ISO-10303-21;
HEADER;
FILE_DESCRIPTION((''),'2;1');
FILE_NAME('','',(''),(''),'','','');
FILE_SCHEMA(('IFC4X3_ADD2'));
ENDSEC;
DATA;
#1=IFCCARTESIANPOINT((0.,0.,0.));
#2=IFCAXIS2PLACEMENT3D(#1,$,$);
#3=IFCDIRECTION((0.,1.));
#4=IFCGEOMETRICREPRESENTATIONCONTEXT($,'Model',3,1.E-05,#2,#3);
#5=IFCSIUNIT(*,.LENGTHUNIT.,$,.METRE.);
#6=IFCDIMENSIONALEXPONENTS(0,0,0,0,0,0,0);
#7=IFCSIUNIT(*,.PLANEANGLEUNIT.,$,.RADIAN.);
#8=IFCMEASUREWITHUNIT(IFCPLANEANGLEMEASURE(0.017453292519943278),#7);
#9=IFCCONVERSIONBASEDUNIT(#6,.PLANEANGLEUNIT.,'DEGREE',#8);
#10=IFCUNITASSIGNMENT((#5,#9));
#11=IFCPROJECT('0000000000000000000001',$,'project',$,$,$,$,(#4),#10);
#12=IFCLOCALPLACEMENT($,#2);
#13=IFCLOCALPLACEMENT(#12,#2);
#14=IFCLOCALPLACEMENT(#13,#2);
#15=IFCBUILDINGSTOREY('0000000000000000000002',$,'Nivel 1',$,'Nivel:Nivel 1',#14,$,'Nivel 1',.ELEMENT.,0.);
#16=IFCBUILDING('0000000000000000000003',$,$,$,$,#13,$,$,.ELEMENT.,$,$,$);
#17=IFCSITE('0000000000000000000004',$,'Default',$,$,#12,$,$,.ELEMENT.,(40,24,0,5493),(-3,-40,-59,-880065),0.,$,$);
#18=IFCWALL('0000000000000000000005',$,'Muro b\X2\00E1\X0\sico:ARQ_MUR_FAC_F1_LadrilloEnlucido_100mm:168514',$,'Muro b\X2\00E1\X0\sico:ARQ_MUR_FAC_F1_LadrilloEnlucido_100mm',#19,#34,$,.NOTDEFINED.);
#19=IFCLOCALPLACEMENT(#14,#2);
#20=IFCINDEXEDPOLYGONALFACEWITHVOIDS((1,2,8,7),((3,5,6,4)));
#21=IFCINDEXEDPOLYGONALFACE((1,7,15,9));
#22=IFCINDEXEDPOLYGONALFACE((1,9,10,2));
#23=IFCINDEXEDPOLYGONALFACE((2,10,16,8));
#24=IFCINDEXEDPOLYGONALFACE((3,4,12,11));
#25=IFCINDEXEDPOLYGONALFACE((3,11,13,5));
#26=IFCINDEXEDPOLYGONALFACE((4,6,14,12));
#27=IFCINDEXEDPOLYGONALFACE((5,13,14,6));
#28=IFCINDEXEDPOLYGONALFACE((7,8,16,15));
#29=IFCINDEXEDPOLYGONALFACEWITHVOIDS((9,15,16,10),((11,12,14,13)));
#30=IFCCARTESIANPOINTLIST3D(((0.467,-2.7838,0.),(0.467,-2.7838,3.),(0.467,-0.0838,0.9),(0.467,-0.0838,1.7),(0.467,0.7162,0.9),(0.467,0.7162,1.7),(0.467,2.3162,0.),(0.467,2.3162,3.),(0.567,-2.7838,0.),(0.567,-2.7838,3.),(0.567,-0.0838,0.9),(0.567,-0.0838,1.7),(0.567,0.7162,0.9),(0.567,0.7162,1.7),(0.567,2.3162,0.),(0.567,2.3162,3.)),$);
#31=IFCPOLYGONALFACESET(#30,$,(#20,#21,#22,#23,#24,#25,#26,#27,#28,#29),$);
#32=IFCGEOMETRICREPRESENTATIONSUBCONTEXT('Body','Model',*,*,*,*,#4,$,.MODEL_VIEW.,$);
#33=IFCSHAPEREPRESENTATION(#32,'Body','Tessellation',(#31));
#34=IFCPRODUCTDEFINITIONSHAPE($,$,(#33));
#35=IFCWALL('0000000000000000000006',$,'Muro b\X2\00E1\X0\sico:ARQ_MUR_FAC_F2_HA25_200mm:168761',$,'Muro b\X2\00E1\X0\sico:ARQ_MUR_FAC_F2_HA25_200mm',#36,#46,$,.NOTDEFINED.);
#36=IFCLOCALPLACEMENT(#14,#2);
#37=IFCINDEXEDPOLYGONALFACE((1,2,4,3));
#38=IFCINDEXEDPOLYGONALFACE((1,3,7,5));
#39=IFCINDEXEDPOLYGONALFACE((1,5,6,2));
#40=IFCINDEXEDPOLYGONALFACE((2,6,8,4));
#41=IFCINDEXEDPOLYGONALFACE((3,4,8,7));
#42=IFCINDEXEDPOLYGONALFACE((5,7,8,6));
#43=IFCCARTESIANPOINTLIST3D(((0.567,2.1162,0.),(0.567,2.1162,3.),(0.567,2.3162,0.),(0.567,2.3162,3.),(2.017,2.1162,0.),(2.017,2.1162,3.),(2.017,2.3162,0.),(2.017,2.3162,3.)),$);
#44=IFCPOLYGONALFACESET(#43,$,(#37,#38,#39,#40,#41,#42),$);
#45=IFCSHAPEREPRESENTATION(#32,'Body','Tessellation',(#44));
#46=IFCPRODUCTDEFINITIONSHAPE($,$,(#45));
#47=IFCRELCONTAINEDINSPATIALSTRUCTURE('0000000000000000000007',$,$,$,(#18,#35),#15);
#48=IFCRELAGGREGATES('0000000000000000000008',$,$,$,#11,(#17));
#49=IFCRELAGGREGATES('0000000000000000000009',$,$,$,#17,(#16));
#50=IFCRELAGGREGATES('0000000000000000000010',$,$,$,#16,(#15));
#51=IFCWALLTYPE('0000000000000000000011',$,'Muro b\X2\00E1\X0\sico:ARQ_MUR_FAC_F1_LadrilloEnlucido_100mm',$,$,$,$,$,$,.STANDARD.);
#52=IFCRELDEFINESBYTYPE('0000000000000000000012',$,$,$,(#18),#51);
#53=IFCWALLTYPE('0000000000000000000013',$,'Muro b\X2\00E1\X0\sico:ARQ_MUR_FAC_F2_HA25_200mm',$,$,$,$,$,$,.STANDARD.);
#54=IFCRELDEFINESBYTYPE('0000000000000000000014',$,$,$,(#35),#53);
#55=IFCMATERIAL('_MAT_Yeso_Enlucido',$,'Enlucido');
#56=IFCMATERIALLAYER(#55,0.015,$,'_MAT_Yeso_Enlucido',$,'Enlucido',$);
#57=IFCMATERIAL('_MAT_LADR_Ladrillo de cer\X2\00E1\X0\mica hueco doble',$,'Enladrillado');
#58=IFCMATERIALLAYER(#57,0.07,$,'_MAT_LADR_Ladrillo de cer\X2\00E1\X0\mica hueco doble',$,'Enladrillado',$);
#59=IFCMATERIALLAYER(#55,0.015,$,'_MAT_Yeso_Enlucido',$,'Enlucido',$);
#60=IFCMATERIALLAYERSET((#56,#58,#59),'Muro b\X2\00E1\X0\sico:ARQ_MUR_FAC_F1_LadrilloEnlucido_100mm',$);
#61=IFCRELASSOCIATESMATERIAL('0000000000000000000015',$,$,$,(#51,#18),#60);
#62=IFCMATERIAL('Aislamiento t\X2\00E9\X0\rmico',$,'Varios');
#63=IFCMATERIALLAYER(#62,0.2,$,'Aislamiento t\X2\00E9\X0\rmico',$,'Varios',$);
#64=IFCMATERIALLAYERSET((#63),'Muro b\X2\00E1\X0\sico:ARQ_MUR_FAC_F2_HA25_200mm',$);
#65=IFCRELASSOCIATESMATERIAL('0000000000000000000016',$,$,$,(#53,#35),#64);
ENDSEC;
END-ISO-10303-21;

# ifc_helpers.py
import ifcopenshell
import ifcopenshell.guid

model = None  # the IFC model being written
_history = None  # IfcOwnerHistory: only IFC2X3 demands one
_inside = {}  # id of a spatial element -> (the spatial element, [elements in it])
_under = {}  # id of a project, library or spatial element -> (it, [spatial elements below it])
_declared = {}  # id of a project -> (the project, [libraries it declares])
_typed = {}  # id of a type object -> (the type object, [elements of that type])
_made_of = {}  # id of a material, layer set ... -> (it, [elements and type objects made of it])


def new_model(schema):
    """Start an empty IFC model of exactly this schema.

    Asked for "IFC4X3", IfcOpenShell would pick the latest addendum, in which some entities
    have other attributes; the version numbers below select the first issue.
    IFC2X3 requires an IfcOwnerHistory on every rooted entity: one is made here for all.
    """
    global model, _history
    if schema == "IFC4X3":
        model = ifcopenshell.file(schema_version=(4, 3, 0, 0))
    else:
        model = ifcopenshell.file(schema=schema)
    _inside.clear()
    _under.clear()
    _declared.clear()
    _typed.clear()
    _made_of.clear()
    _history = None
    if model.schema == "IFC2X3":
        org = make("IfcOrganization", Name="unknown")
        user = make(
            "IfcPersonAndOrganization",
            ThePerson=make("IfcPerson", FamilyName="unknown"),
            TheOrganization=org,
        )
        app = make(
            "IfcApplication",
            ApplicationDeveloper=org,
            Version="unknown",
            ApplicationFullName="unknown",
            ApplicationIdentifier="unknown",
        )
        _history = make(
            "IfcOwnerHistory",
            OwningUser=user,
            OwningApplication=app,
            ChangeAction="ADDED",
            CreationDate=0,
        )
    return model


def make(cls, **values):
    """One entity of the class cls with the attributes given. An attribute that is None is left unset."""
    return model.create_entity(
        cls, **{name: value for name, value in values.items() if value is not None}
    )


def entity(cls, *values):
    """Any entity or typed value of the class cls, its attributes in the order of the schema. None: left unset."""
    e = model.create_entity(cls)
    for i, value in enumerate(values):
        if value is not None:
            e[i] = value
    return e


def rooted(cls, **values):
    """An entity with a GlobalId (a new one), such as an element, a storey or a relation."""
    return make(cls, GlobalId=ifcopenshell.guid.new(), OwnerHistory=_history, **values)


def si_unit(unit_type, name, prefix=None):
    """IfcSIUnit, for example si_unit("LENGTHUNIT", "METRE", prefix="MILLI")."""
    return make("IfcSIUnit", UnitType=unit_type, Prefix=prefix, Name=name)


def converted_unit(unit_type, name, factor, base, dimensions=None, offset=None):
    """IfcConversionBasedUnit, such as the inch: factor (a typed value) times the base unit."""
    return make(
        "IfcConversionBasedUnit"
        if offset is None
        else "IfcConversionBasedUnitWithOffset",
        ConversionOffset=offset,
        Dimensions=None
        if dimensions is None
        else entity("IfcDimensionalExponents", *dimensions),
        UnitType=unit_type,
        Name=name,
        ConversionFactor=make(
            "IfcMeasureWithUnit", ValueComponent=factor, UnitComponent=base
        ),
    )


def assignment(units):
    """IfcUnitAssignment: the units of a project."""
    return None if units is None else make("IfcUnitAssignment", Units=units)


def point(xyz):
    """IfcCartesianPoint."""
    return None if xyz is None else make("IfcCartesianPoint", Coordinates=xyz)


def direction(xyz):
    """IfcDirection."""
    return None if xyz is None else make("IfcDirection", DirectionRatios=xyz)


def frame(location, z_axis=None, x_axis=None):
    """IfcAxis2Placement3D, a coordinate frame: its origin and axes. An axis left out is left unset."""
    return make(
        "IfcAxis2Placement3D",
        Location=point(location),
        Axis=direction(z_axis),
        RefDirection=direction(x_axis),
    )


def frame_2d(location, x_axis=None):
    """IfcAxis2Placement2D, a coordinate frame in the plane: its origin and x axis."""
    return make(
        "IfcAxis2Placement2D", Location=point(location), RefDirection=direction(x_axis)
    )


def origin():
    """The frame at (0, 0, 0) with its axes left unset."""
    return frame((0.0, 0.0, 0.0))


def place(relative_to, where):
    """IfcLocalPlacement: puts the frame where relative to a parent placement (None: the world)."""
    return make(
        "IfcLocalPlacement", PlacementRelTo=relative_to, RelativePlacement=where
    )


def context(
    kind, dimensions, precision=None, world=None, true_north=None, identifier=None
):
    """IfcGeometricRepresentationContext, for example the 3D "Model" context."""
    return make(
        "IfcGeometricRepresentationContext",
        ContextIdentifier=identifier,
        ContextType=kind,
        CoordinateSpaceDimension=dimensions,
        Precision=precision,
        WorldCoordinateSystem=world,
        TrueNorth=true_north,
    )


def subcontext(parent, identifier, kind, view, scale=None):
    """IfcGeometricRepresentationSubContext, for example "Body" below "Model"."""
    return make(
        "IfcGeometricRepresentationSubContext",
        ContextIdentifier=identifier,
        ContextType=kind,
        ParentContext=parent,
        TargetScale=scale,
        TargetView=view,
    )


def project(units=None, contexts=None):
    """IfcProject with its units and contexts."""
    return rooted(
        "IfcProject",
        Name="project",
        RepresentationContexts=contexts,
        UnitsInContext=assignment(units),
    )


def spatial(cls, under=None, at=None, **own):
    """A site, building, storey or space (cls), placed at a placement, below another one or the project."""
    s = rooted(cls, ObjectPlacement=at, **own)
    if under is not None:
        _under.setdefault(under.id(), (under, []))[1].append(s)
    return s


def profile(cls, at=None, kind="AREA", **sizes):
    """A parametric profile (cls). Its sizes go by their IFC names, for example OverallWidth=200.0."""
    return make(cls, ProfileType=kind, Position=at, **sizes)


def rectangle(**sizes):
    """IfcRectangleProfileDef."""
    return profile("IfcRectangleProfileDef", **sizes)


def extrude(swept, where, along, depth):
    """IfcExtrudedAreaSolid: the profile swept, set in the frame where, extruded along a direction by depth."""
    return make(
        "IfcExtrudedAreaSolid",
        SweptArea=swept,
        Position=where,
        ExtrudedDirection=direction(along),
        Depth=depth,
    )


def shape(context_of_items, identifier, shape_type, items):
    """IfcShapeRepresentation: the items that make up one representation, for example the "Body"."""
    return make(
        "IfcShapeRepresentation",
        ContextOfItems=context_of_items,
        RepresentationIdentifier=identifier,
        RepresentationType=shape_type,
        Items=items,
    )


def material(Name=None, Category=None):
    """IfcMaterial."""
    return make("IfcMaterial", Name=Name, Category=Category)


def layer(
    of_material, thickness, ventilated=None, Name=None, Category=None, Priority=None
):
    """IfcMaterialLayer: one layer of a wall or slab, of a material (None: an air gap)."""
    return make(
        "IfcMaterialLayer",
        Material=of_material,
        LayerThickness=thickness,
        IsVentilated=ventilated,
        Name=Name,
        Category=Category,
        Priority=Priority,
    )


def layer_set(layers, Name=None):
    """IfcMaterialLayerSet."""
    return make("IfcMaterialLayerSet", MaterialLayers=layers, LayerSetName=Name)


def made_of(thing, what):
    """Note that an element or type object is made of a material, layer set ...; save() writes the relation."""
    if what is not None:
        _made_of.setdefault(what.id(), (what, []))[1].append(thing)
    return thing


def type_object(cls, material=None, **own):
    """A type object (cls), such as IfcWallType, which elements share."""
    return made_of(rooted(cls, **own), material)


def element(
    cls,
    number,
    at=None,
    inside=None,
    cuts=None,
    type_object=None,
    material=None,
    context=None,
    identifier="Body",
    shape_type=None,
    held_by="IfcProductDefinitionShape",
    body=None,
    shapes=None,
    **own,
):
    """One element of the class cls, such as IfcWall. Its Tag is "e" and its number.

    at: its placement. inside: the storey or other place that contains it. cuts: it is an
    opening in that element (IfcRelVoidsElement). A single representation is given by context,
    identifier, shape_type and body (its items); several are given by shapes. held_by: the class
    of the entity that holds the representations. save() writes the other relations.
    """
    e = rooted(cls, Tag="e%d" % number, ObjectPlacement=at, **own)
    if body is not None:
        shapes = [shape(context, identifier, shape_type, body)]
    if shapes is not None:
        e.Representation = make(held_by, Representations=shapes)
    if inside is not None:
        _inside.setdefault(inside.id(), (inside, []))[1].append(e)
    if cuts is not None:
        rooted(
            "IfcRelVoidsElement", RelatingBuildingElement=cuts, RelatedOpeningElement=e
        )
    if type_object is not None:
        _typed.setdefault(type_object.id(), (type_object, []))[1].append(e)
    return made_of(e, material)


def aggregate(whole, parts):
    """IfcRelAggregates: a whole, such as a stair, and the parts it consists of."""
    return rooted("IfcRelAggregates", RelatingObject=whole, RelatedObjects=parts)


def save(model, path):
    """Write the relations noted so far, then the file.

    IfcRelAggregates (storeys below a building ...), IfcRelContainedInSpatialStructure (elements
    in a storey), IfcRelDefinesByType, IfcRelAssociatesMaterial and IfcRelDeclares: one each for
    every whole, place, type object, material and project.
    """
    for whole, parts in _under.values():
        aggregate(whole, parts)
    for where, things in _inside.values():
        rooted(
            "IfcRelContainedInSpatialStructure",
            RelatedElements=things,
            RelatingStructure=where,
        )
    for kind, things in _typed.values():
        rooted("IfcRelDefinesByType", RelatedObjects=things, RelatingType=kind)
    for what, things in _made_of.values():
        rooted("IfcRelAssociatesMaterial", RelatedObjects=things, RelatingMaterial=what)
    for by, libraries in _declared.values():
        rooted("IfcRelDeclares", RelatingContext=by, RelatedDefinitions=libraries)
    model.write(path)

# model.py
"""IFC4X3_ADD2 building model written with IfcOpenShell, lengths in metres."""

from ifc_helpers import new_model, entity, si_unit, converted_unit, direction, frame, frame_2d, origin, place, context, subcontext, project, spatial, rectangle, extrude, material, layer, layer_set, type_object, element, save


model = new_model("IFC4X3_ADD2")

# Units and contexts
model_context = context("Model", 3, precision=1e-05, world=origin(), true_north=direction((0.0, 1.0)))
body_context = subcontext(model_context, "Body", "Model", "MODEL_VIEW")
ifc_project = project(units=[si_unit("LENGTHUNIT", "METRE"), converted_unit("PLANEANGLEUNIT", "DEGREE", entity("IfcPlaneAngleMeasure", 0.017453292519943278), si_unit("PLANEANGLEUNIT", "RADIAN"), dimensions=[0, 0, 0, 0, 0, 0, 0])], contexts=[model_context])

# Site, building, storey
site_placement = place(None, origin())
site = spatial("IfcSite", under=ifc_project, at=site_placement, Name="Default", CompositionType="ELEMENT", RefLatitude=(40, 24, 0, 5493), RefLongitude=(-3, -40, -59, -880065), RefElevation=0.0)
building_placement = place(site_placement, origin())
building = spatial("IfcBuilding", under=site, at=building_placement, CompositionType="ELEMENT")
storey_placement = place(building_placement, origin())
storey = spatial("IfcBuildingStorey", under=building, at=storey_placement, Name="Nivel 1", ObjectType="Nivel:Nivel 1", LongName="Nivel 1", CompositionType="ELEMENT", Elevation=0.0)

# Wall, opening
ifc_material_1 = material(Name="_MAT_Yeso_Enlucido", Category="Enlucido")
ifc_layer_1 = layer(ifc_material_1, 0.015, Name="_MAT_Yeso_Enlucido", Category="Enlucido")
ifc_material_2 = material(Name="_MAT_LADR_Ladrillo de cerámica hueco doble", Category="Enladrillado")
ifc_layer_2 = layer(ifc_material_2, 0.07, Name="_MAT_LADR_Ladrillo de cerámica hueco doble", Category="Enladrillado")
ifc_layer_3 = layer(ifc_material_1, 0.015, Name="_MAT_Yeso_Enlucido", Category="Enlucido")
ifc_layer_set_1 = layer_set([ifc_layer_1, ifc_layer_2, ifc_layer_3], Name="Muro básico:ARQ_MUR_FAC_F1_LadrilloEnlucido_100mm")
wall_type_1 = type_object("IfcWallType", Name="Muro básico:ARQ_MUR_FAC_F1_LadrilloEnlucido_100mm", PredefinedType="STANDARD", material=ifc_layer_set_1)
wall_1_placement = place(storey_placement, frame((0.517, -2.7838, 0.0), z_axis=(0.0, 0.0, 1.0), x_axis=(0.0, 1.0, 0.0)))
wall_1 = element("IfcWall", 1, at=wall_1_placement, inside=storey, type_object=wall_type_1, material=ifc_layer_set_1, Name="Muro básico:ARQ_MUR_FAC_F1_LadrilloEnlucido_100mm:168514", ObjectType="Muro básico:ARQ_MUR_FAC_F1_LadrilloEnlucido_100mm", PredefinedType="NOTDEFINED", context=body_context, shape_type="SweptSolid", body=[
    extrude(rectangle(XDim=5.1, YDim=0.1, at=frame_2d((2.55, 0.0), x_axis=(-1.0, 0.0))), origin(), (0.0, 0.0, 1.0), 3.0),
])
opening_placement = place(wall_1_placement, frame((2.7, -0.05, 0.9)))
element("IfcOpeningElement", 2, at=opening_placement, cuts=wall_1, PredefinedType="OPENING", context=body_context, shape_type="SweptSolid", body=[
    extrude(rectangle(XDim=0.8, YDim=0.8, at=frame_2d((0.4, 0.4), x_axis=(1.0, 0.0))), frame((0.0, 0.0, 0.0), z_axis=(0.0, 1.0, 0.0), x_axis=(0.0, 0.0, 1.0)), (0.0, 0.0, 1.0), 0.1),
])

# Wall
ifc_material_3 = material(Name="Aislamiento térmico", Category="Varios")
ifc_layer_4 = layer(ifc_material_3, 0.2, Name="Aislamiento térmico", Category="Varios")
ifc_layer_set_2 = layer_set([ifc_layer_4], Name="Muro básico:ARQ_MUR_FAC_F2_HA25_200mm")
wall_type_2 = type_object("IfcWallType", Name="Muro básico:ARQ_MUR_FAC_F2_HA25_200mm", PredefinedType="STANDARD", material=ifc_layer_set_2)
wall_2_placement = place(storey_placement, frame((0.567, 2.2162, 0.0)))
element("IfcWall", 3, at=wall_2_placement, inside=storey, type_object=wall_type_2, material=ifc_layer_set_2, Name="Muro básico:ARQ_MUR_FAC_F2_HA25_200mm:168761", ObjectType="Muro básico:ARQ_MUR_FAC_F2_HA25_200mm", PredefinedType="NOTDEFINED", context=body_context, shape_type="SweptSolid", body=[
    extrude(rectangle(XDim=1.45, YDim=0.2, at=frame_2d((0.725, 0.0), x_axis=(-1.0, 0.0))), origin(), (0.0, 0.0, 1.0), 3.0),
])

save(model, "model.ifc")
